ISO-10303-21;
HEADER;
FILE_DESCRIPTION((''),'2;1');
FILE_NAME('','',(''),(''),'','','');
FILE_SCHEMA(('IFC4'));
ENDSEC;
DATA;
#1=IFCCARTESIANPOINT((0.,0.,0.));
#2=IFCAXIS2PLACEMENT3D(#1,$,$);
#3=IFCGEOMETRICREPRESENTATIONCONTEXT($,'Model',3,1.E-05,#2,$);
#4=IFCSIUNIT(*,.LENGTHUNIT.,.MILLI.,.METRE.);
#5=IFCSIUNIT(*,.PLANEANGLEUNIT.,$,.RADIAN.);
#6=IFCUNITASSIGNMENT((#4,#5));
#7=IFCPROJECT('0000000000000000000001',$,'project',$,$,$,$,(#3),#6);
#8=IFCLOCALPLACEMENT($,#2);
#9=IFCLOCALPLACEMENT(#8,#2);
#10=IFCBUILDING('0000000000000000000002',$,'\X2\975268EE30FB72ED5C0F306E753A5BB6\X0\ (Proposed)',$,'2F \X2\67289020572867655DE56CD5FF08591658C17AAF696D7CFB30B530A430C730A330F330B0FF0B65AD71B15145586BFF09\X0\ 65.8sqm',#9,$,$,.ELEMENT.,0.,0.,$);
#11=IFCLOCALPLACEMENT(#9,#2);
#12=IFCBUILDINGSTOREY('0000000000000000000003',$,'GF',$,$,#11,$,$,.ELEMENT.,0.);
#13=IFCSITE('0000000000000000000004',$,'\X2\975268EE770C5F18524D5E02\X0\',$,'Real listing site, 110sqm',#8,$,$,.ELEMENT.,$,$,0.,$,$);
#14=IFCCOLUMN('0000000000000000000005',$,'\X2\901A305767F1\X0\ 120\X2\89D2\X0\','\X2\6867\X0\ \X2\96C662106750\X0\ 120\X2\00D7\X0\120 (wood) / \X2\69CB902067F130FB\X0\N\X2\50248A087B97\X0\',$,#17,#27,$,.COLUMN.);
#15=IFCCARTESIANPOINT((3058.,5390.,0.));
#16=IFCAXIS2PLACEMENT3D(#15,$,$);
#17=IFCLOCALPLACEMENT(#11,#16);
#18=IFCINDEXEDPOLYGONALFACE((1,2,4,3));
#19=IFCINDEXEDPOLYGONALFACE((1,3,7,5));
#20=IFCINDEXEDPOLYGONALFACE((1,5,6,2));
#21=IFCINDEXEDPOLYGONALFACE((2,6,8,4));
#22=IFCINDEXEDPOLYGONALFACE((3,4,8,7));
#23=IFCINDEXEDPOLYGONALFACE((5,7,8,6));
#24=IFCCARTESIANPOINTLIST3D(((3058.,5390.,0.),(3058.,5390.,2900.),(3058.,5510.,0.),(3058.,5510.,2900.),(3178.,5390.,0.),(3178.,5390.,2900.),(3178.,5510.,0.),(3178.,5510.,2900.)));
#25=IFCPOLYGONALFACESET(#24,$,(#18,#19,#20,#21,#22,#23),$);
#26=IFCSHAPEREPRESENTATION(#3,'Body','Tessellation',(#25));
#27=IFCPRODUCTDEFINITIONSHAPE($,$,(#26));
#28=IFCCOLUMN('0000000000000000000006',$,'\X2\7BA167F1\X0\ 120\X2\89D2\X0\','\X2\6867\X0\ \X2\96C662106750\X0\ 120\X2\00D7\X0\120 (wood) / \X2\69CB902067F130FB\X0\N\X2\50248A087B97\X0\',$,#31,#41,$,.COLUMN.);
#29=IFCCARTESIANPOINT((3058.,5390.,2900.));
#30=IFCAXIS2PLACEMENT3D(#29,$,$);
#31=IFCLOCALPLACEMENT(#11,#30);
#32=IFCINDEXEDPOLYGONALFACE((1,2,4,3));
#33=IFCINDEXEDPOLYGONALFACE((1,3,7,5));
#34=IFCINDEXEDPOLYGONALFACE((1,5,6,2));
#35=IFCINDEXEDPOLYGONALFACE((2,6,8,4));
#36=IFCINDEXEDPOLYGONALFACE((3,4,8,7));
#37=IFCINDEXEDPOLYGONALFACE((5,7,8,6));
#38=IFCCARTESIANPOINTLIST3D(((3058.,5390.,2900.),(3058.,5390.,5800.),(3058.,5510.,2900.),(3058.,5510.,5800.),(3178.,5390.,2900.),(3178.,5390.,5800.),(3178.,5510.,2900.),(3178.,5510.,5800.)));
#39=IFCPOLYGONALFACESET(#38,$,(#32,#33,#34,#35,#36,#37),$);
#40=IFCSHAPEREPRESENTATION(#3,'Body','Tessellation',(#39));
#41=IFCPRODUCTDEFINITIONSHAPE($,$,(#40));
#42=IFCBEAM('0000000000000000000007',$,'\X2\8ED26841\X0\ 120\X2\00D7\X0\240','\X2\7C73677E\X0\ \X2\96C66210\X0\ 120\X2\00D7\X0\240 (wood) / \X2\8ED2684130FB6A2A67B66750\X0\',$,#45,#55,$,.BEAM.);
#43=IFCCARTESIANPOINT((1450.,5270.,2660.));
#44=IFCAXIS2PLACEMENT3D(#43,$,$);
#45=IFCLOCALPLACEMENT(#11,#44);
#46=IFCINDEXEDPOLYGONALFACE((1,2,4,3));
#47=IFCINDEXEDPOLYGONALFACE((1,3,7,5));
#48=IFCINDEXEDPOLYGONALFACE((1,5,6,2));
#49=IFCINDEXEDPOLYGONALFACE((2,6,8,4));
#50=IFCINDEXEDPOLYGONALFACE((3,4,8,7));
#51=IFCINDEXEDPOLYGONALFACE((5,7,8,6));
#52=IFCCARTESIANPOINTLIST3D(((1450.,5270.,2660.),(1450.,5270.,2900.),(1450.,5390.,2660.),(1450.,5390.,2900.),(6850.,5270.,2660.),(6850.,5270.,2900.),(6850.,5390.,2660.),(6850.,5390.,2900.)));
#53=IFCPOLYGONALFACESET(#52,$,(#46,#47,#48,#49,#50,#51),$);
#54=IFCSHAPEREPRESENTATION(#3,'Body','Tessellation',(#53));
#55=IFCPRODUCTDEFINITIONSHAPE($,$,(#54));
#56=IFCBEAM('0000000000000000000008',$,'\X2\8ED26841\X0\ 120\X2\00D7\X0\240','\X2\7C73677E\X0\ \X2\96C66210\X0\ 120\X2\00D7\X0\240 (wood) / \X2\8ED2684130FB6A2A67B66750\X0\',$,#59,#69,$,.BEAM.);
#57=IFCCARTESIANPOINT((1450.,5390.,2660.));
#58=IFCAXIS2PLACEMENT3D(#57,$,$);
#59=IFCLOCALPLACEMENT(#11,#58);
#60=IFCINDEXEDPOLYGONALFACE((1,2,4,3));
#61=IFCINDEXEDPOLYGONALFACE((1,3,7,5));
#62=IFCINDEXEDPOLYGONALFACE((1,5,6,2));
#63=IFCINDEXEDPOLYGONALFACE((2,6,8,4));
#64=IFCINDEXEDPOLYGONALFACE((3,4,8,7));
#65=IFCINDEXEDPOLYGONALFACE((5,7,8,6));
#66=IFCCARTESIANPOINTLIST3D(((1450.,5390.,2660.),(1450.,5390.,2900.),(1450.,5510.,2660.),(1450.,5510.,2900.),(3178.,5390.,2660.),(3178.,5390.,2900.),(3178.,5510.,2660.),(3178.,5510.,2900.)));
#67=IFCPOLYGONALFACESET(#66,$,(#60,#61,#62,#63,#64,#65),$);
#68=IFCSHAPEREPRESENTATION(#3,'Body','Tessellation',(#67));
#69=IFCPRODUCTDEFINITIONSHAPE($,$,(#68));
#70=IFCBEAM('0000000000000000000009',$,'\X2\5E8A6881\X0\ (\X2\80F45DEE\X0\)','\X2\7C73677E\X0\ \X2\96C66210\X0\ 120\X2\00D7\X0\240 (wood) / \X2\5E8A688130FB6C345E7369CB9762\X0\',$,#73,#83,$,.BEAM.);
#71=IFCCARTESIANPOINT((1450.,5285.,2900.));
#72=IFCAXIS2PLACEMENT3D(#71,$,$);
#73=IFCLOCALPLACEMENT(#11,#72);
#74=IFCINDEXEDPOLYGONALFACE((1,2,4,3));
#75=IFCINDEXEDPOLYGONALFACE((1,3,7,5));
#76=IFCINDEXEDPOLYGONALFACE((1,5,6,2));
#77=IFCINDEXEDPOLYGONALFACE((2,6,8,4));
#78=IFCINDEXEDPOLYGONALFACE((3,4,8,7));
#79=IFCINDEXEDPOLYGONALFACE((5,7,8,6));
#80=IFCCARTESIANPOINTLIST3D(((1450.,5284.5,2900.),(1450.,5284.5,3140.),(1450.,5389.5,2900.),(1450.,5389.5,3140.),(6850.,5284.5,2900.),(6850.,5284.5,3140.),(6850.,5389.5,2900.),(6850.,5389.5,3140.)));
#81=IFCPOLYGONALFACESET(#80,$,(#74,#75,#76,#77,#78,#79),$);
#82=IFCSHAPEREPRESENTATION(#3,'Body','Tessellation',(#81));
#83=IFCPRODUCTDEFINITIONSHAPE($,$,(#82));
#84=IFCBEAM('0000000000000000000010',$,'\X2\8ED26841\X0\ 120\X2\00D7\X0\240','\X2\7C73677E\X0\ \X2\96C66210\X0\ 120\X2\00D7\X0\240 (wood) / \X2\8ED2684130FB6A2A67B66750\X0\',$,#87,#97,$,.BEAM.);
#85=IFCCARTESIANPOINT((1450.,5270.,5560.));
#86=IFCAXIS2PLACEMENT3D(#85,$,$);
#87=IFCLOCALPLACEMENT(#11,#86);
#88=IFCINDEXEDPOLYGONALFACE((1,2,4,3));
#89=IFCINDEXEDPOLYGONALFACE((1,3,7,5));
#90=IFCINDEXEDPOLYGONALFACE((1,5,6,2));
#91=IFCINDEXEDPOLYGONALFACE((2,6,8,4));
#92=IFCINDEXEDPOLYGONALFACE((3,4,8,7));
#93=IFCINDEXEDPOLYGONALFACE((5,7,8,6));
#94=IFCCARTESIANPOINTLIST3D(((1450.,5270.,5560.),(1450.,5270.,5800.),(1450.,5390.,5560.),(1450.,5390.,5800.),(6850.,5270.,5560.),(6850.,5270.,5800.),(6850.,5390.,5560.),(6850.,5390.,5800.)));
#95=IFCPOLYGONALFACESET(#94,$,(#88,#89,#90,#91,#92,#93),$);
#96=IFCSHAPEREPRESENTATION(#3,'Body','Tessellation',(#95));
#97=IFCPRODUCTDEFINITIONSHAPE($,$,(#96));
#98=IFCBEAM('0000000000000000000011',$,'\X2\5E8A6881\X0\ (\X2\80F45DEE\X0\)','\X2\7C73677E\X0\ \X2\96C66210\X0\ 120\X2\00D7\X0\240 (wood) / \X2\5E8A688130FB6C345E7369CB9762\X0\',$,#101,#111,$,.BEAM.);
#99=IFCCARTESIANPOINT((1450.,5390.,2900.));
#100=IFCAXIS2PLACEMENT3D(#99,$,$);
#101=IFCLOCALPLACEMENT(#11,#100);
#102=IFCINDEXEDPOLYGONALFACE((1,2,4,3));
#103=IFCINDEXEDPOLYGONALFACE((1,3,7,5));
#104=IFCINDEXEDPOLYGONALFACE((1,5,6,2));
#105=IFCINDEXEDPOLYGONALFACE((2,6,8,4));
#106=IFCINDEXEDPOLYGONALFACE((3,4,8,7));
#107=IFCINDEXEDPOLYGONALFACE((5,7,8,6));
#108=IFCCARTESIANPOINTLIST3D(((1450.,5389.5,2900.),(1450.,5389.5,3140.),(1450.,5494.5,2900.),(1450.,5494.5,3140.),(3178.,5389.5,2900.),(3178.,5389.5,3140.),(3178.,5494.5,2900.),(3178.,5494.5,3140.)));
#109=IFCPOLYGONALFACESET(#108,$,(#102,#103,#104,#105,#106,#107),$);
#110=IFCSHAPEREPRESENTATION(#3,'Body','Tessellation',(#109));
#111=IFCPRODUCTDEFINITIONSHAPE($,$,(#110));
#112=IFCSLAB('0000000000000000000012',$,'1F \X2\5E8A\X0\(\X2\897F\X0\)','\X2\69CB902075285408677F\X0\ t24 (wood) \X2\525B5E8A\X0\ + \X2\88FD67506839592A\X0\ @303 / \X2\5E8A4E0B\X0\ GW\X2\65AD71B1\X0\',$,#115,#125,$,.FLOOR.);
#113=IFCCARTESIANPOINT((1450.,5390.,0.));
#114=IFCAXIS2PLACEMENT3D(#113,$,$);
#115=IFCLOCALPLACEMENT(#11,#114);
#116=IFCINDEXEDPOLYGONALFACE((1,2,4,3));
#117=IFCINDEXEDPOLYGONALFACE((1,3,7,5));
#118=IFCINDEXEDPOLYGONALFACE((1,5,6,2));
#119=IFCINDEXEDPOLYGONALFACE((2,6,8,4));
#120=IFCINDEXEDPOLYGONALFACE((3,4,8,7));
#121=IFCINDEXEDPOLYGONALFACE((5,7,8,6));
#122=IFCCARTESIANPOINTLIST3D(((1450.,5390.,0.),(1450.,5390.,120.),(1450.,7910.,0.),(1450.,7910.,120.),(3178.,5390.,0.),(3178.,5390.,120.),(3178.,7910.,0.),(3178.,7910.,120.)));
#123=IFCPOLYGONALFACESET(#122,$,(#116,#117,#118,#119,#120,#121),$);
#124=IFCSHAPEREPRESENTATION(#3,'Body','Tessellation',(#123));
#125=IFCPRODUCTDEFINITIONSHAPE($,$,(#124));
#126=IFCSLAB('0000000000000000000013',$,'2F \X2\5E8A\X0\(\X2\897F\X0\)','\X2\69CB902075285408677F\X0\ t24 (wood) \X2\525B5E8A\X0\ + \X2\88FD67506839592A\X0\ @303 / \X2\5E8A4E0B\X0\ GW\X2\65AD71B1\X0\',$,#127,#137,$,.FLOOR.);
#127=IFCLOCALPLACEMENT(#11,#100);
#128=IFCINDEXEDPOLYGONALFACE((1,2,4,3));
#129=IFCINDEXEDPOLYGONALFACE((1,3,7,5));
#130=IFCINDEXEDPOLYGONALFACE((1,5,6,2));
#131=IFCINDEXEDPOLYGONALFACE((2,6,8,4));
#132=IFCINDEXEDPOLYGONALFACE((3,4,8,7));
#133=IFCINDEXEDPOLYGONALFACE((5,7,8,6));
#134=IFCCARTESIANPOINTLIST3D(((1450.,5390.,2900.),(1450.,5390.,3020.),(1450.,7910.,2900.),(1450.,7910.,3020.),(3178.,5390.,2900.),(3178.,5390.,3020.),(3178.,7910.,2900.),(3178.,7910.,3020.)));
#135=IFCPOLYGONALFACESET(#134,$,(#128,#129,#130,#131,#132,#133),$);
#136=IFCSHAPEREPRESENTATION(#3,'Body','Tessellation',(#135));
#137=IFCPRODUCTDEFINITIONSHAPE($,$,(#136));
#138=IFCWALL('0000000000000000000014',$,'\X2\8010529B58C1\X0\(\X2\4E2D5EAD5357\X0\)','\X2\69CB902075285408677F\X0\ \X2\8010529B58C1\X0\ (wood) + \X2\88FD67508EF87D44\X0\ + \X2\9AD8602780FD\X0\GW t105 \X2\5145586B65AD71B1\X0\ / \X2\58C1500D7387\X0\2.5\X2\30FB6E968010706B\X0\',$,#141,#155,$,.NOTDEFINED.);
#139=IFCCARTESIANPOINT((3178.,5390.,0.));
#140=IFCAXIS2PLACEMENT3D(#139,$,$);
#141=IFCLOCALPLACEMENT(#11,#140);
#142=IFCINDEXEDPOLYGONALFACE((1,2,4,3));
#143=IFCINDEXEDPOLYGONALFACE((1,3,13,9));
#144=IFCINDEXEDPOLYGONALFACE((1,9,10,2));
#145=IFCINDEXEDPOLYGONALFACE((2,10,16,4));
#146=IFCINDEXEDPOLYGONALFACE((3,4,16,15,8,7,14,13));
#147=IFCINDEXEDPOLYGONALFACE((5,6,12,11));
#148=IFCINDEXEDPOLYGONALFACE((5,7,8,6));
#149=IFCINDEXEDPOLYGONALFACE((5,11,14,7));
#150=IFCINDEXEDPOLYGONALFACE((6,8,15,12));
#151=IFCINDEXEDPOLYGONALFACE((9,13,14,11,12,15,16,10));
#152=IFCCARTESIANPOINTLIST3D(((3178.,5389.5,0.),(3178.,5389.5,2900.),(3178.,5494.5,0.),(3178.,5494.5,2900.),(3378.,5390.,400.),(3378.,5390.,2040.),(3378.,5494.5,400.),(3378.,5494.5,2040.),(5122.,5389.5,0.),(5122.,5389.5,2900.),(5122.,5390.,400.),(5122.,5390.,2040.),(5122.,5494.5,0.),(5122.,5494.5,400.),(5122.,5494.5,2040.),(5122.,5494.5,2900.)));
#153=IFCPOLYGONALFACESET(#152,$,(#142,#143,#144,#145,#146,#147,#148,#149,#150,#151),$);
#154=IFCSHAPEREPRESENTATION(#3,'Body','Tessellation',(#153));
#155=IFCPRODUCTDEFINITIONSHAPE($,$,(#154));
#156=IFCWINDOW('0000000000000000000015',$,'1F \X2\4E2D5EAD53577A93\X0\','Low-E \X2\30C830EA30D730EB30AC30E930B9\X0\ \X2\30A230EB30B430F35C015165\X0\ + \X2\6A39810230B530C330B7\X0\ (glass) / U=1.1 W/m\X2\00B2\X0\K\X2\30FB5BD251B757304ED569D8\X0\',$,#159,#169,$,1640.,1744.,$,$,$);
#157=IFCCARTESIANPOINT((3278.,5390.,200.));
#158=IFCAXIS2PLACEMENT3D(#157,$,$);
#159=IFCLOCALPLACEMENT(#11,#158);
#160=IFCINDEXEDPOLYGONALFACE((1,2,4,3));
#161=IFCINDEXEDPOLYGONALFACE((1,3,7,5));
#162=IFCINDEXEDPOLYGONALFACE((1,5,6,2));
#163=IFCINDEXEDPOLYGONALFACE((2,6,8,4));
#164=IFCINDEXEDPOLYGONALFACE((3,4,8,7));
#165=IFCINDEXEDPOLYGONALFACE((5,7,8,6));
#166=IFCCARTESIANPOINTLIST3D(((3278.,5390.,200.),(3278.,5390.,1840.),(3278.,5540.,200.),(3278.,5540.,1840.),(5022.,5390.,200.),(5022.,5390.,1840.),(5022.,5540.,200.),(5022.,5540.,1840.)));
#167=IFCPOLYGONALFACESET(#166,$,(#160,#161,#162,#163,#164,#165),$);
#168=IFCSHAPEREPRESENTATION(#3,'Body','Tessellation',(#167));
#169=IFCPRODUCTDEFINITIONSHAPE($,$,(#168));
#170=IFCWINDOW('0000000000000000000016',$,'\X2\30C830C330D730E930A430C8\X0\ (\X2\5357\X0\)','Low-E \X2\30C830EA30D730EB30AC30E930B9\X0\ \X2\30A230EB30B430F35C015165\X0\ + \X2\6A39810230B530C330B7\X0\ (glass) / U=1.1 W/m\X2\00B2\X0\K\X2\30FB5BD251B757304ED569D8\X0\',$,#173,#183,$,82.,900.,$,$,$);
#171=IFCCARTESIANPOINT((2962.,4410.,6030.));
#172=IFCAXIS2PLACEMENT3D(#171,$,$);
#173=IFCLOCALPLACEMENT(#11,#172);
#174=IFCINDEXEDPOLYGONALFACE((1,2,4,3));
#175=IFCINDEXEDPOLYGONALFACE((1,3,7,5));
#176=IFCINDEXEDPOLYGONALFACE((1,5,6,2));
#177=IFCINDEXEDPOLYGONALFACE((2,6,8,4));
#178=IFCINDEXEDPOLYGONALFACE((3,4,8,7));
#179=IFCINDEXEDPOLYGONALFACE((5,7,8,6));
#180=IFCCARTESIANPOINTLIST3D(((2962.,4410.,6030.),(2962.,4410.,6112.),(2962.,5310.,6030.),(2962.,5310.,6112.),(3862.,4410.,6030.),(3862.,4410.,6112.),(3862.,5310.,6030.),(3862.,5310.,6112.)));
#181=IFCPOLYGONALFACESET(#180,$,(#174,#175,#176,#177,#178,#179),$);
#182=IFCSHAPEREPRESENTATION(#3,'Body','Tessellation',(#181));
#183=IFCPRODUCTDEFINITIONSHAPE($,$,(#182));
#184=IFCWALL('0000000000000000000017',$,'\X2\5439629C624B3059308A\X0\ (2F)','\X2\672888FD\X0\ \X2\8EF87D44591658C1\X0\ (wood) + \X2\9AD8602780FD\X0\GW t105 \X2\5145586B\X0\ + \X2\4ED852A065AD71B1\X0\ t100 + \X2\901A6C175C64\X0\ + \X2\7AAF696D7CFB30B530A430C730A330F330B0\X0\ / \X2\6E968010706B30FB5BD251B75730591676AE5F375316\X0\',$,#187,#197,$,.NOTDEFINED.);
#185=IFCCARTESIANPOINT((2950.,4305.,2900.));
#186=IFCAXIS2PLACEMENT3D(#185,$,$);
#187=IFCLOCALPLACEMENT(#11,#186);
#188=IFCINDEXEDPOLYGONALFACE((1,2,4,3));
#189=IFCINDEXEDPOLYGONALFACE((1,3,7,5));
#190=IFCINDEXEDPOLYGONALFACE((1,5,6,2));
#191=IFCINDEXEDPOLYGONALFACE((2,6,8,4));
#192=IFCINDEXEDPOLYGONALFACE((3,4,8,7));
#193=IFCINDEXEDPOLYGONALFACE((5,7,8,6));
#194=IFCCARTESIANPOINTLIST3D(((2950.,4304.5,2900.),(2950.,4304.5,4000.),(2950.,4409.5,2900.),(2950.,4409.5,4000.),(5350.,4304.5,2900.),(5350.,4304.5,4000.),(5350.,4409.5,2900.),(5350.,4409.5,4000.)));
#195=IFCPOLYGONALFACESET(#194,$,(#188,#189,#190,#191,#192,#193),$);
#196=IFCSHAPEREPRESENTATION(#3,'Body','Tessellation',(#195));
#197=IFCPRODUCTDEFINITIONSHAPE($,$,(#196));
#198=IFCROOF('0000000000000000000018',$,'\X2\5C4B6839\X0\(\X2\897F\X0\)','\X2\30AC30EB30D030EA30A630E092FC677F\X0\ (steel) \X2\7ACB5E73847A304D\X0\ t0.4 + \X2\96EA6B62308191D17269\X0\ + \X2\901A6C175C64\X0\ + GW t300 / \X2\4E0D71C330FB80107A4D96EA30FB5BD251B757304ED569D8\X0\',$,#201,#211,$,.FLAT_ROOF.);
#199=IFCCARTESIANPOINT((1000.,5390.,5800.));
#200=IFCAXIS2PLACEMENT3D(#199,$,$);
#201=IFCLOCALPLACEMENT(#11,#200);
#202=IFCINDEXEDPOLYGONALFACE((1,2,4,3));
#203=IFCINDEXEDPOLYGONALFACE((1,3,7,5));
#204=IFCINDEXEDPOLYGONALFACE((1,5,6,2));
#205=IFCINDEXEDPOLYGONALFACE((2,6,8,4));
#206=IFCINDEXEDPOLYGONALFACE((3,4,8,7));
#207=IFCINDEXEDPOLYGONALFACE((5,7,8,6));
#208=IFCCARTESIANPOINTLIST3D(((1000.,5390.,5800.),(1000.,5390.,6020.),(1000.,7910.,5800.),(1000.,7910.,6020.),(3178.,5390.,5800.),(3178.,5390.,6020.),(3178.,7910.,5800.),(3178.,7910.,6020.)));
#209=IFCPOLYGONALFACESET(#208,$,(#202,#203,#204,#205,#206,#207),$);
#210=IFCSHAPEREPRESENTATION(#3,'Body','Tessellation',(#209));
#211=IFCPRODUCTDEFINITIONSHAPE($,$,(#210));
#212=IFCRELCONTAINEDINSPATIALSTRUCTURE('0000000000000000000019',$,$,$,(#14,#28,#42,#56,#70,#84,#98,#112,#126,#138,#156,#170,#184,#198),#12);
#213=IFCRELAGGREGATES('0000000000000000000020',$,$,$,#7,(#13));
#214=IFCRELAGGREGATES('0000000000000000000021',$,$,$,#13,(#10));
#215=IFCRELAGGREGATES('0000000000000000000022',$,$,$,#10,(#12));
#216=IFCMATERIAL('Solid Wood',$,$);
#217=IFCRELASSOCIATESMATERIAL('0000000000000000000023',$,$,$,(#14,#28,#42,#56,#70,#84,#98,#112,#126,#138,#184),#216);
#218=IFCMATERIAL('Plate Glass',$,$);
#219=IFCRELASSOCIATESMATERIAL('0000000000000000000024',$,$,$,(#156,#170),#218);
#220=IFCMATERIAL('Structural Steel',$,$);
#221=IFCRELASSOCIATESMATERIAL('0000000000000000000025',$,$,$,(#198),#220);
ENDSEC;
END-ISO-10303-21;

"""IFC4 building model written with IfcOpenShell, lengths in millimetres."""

from ifc_helpers import new_model, si_unit, frame, frame_2d, origin, place, context, project, spatial, rectangle, extrude, material, element, fill, save


model = new_model("IFC4")

# Units and contexts
model_context = context("Model", 3, precision=1e-05, world=origin())
ifc_project = project(units=[si_unit("LENGTHUNIT", "METRE", prefix="MILLI"), si_unit("PLANEANGLEUNIT", "RADIAN")], contexts=[model_context])

# Site, building, storey
site_placement = place(None, origin())
site = spatial("IfcSite", under=ifc_project, at=site_placement, Name="青森県弘前市", ObjectType="Real listing site, 110sqm", CompositionType="ELEMENT", RefElevation=0.0)
building_placement = place(site_placement, origin())
building = spatial("IfcBuilding", under=site, at=building_placement, Name="青森・狭小の町家 (Proposed)", ObjectType="2F 木造在来工法（外壁窯業系サイディング＋断熱充填） 65.8sqm", CompositionType="ELEMENT", ElevationOfRefHeight=0.0, ElevationOfTerrain=0.0)
storey_placement = place(building_placement, origin())
storey = spatial("IfcBuildingStorey", under=building, at=storey_placement, Name="GF", CompositionType="ELEMENT", Elevation=0.0)

# Columns
ifc_material_1 = material(Name="Solid Wood")
column_1_placement = place(storey_placement, frame((3058.0, 5390.0, 0.0)))
element("IfcColumn", 1, at=column_1_placement, inside=storey, material=ifc_material_1, Name="通し柱 120角", Description="桧 集成材 120×120 (wood) / 構造柱・N値計算", PredefinedType="COLUMN", context=model_context, shape_type="SweptSolid", body=[
    extrude(rectangle(XDim=120.0, YDim=120.0, at=frame_2d((60.0, 60.0))), frame((3058.0, 5390.0, 0.0)), (0.0, 0.0, 1.0), 2900.0),
])
column_2_placement = place(storey_placement, frame((3058.0, 5390.0, 2900.0)))
element("IfcColumn", 2, at=column_2_placement, inside=storey, material=ifc_material_1, Name="管柱 120角", Description="桧 集成材 120×120 (wood) / 構造柱・N値計算", PredefinedType="COLUMN", context=model_context, shape_type="SweptSolid", body=[
    extrude(rectangle(XDim=120.0, YDim=120.0, at=frame_2d((60.0, 60.0))), frame((3058.0, 5390.0, 2900.0)), (0.0, 0.0, 1.0), 2900.0),
])

# Beams
beam_1_placement = place(storey_placement, frame((1450.0, 5270.0, 2660.0)))
element("IfcBeam", 3, at=beam_1_placement, inside=storey, material=ifc_material_1, Name="軒桁 120×240", Description="米松 集成 120×240 (wood) / 軒桁・横架材", PredefinedType="BEAM", context=model_context, shape_type="SweptSolid", body=[
    extrude(rectangle(XDim=5400.0, YDim=120.0, at=frame_2d((2700.0, 60.0))), frame((1450.0, 5270.0, 2660.0)), (0.0, 0.0, 1.0), 240.0),
])
beam_2_placement = place(storey_placement, frame((1450.0, 5390.0, 2660.0)))
element("IfcBeam", 4, at=beam_2_placement, inside=storey, material=ifc_material_1, Name="軒桁 120×240", Description="米松 集成 120×240 (wood) / 軒桁・横架材", PredefinedType="BEAM", context=model_context, shape_type="SweptSolid", body=[
    extrude(rectangle(XDim=1728.0, YDim=120.0, at=frame_2d((864.0, 60.0))), frame((1450.0, 5390.0, 2660.0)), (0.0, 0.0, 1.0), 240.0),
])
beam_3_placement = place(storey_placement, frame((1450.0, 5285.0, 2900.0)))
element("IfcBeam", 5, at=beam_3_placement, inside=storey, material=ifc_material_1, Name="床梁 (胴差)", Description="米松 集成 120×240 (wood) / 床梁・水平構面", PredefinedType="BEAM", context=model_context, shape_type="SweptSolid", body=[
    extrude(rectangle(XDim=5400.0, YDim=105.0, at=frame_2d((2700.0, 52.0))), frame((1450.0, 5285.0, 2900.0)), (0.0, 0.0, 1.0), 240.0),
])
beam_4_placement = place(storey_placement, frame((1450.0, 5270.0, 5560.0)))
element("IfcBeam", 6, at=beam_4_placement, inside=storey, material=ifc_material_1, Name="軒桁 120×240", Description="米松 集成 120×240 (wood) / 軒桁・横架材", PredefinedType="BEAM", context=model_context, shape_type="SweptSolid", body=[
    extrude(rectangle(XDim=5400.0, YDim=120.0, at=frame_2d((2700.0, 60.0))), frame((1450.0, 5270.0, 5560.0)), (0.0, 0.0, 1.0), 240.0),
])
beam_5_placement = place(storey_placement, frame((1450.0, 5390.0, 2900.0)))
element("IfcBeam", 7, at=beam_5_placement, inside=storey, material=ifc_material_1, Name="床梁 (胴差)", Description="米松 集成 120×240 (wood) / 床梁・水平構面", PredefinedType="BEAM", context=model_context, shape_type="SweptSolid", body=[
    extrude(rectangle(XDim=1728.0, YDim=105.0, at=frame_2d((864.0, 52.0))), frame((1450.0, 5390.0, 2900.0)), (0.0, 0.0, 1.0), 240.0),
])

# Slabs
slab_1_placement = place(storey_placement, frame((1450.0, 5390.0, 0.0)))
element("IfcSlab", 8, at=slab_1_placement, inside=storey, material=ifc_material_1, Name="1F 床(西)", Description="構造用合板 t24 (wood) 剛床 + 製材根太 @303 / 床下 GW断熱", PredefinedType="FLOOR", context=model_context, shape_type="SweptSolid", body=[
    extrude(rectangle(XDim=1728.0, YDim=2520.0, at=frame_2d((864.0, 1260.0))), frame((1450.0, 5390.0, 0.0)), (0.0, 0.0, 1.0), 120.0),
])
slab_2_placement = place(storey_placement, frame((1450.0, 5390.0, 2900.0)))
element("IfcSlab", 9, at=slab_2_placement, inside=storey, material=ifc_material_1, Name="2F 床(西)", Description="構造用合板 t24 (wood) 剛床 + 製材根太 @303 / 床下 GW断熱", PredefinedType="FLOOR", context=model_context, shape_type="SweptSolid", body=[
    extrude(rectangle(XDim=1728.0, YDim=2520.0, at=frame_2d((864.0, 1260.0))), frame((1450.0, 5390.0, 2900.0)), (0.0, 0.0, 1.0), 120.0),
])

# Wall, opening, window
wall_1_placement = place(storey_placement, frame((3178.0, 5390.0, 0.0)))
wall_1 = element("IfcWall", 10, at=wall_1_placement, inside=storey, material=ifc_material_1, Name="耐力壁(中庭南)", Description="構造用合板 耐力壁 (wood) + 製材軸組 + 高性能GW t105 充填断熱 / 壁倍率2.5・準耐火", PredefinedType="NOTDEFINED", context=model_context, shape_type="SweptSolid", body=[
    extrude(rectangle(XDim=1944.0, YDim=105.0, at=frame_2d((972.0, 52.0))), frame((3178.0, 5390.0, 0.0)), (0.0, 0.0, 1.0), 2900.0),
])
opening_placement = place(storey_placement, frame((3278.0, 5390.0, 200.0)))
opening = element("IfcOpeningElement", 11, at=opening_placement, cuts=wall_1, PredefinedType="NOTDEFINED", context=model_context, shape_type="SweptSolid", body=[
    extrude(rectangle(XDim=1744.0, YDim=150.0, at=frame_2d((872.0, 75.0))), frame((3278.0, 5390.0, 200.0)), (0.0, 0.0, 1.0), 1640.0),
])
ifc_material_2 = material(Name="Plate Glass")
window_1_placement = place(storey_placement, frame((3278.0, 5390.0, 200.0)))
window_1 = element("IfcWindow", 12, at=window_1_placement, inside=storey, material=ifc_material_2, Name="1F 中庭南窓", Description="Low-E トリプルガラス アルゴン封入 + 樹脂サッシ (glass) / U=1.1 W/m²K・寒冷地仕様", OverallHeight=1640.0, OverallWidth=1744.0, context=model_context, shape_type="SweptSolid", body=[
    extrude(rectangle(XDim=1744.0, YDim=150.0, at=frame_2d((872.0, 75.0))), frame((3278.0, 5390.0, 200.0)), (0.0, 0.0, 1.0), 1640.0),
])
fill(opening, window_1)

# Window
window_2_placement = place(storey_placement, frame((2962.0, 4410.0, 6030.0)))
element("IfcWindow", 13, at=window_2_placement, inside=storey, material=ifc_material_2, Name="トップライト (南)", Description="Low-E トリプルガラス アルゴン封入 + 樹脂サッシ (glass) / U=1.1 W/m²K・寒冷地仕様", OverallHeight=82.0, OverallWidth=900.0, context=model_context, shape_type="SweptSolid", body=[
    extrude(rectangle(XDim=900.0, YDim=900.0, at=frame_2d((450.0, 450.0))), frame((2962.0, 4410.0, 6030.0)), (0.0, 0.0, 1.0), 82.0),
])

# Wall
wall_2_placement = place(storey_placement, frame((2950.0, 4305.0, 2900.0)))
element("IfcWall", 14, at=wall_2_placement, inside=storey, material=ifc_material_1, Name="吹抜手すり (2F)", Description="木製 軸組外壁 (wood) + 高性能GW t105 充填 + 付加断熱 t100 + 通気層 + 窯業系サイディング / 準耐火・寒冷地外皮強化", PredefinedType="NOTDEFINED", context=model_context, shape_type="SweptSolid", body=[
    extrude(rectangle(XDim=2400.0, YDim=105.0, at=frame_2d((1200.0, 52.0))), frame((2950.0, 4305.0, 2900.0)), (0.0, 0.0, 1.0), 1100.0),
])

# Roof
ifc_material_3 = material(Name="Structural Steel")
for number, where, name in (
    (15, (1000.0, 5390.0, 5800.0), "屋根(西)"),
):
    element("IfcRoof", number, at=place(storey_placement, frame(where)), inside=storey, material=ifc_material_3, Name=name, Description="ガルバリウム鋼板 (steel) 立平葺き t0.4 + 雪止め金物 + 通気層 + GW t300 / 不燃・耐積雪・寒冷地仕様", PredefinedType="FLAT_ROOF", context=model_context, shape_type="SweptSolid", body=[
        extrude(rectangle(XDim=2178.0, YDim=2520.0, at=frame_2d((1089.0, 1260.0))), frame((1000.0, 5390.0, 5800.0)), (0.0, 0.0, 1.0), 220.0),
    ])

save(model, "model.ifc")
